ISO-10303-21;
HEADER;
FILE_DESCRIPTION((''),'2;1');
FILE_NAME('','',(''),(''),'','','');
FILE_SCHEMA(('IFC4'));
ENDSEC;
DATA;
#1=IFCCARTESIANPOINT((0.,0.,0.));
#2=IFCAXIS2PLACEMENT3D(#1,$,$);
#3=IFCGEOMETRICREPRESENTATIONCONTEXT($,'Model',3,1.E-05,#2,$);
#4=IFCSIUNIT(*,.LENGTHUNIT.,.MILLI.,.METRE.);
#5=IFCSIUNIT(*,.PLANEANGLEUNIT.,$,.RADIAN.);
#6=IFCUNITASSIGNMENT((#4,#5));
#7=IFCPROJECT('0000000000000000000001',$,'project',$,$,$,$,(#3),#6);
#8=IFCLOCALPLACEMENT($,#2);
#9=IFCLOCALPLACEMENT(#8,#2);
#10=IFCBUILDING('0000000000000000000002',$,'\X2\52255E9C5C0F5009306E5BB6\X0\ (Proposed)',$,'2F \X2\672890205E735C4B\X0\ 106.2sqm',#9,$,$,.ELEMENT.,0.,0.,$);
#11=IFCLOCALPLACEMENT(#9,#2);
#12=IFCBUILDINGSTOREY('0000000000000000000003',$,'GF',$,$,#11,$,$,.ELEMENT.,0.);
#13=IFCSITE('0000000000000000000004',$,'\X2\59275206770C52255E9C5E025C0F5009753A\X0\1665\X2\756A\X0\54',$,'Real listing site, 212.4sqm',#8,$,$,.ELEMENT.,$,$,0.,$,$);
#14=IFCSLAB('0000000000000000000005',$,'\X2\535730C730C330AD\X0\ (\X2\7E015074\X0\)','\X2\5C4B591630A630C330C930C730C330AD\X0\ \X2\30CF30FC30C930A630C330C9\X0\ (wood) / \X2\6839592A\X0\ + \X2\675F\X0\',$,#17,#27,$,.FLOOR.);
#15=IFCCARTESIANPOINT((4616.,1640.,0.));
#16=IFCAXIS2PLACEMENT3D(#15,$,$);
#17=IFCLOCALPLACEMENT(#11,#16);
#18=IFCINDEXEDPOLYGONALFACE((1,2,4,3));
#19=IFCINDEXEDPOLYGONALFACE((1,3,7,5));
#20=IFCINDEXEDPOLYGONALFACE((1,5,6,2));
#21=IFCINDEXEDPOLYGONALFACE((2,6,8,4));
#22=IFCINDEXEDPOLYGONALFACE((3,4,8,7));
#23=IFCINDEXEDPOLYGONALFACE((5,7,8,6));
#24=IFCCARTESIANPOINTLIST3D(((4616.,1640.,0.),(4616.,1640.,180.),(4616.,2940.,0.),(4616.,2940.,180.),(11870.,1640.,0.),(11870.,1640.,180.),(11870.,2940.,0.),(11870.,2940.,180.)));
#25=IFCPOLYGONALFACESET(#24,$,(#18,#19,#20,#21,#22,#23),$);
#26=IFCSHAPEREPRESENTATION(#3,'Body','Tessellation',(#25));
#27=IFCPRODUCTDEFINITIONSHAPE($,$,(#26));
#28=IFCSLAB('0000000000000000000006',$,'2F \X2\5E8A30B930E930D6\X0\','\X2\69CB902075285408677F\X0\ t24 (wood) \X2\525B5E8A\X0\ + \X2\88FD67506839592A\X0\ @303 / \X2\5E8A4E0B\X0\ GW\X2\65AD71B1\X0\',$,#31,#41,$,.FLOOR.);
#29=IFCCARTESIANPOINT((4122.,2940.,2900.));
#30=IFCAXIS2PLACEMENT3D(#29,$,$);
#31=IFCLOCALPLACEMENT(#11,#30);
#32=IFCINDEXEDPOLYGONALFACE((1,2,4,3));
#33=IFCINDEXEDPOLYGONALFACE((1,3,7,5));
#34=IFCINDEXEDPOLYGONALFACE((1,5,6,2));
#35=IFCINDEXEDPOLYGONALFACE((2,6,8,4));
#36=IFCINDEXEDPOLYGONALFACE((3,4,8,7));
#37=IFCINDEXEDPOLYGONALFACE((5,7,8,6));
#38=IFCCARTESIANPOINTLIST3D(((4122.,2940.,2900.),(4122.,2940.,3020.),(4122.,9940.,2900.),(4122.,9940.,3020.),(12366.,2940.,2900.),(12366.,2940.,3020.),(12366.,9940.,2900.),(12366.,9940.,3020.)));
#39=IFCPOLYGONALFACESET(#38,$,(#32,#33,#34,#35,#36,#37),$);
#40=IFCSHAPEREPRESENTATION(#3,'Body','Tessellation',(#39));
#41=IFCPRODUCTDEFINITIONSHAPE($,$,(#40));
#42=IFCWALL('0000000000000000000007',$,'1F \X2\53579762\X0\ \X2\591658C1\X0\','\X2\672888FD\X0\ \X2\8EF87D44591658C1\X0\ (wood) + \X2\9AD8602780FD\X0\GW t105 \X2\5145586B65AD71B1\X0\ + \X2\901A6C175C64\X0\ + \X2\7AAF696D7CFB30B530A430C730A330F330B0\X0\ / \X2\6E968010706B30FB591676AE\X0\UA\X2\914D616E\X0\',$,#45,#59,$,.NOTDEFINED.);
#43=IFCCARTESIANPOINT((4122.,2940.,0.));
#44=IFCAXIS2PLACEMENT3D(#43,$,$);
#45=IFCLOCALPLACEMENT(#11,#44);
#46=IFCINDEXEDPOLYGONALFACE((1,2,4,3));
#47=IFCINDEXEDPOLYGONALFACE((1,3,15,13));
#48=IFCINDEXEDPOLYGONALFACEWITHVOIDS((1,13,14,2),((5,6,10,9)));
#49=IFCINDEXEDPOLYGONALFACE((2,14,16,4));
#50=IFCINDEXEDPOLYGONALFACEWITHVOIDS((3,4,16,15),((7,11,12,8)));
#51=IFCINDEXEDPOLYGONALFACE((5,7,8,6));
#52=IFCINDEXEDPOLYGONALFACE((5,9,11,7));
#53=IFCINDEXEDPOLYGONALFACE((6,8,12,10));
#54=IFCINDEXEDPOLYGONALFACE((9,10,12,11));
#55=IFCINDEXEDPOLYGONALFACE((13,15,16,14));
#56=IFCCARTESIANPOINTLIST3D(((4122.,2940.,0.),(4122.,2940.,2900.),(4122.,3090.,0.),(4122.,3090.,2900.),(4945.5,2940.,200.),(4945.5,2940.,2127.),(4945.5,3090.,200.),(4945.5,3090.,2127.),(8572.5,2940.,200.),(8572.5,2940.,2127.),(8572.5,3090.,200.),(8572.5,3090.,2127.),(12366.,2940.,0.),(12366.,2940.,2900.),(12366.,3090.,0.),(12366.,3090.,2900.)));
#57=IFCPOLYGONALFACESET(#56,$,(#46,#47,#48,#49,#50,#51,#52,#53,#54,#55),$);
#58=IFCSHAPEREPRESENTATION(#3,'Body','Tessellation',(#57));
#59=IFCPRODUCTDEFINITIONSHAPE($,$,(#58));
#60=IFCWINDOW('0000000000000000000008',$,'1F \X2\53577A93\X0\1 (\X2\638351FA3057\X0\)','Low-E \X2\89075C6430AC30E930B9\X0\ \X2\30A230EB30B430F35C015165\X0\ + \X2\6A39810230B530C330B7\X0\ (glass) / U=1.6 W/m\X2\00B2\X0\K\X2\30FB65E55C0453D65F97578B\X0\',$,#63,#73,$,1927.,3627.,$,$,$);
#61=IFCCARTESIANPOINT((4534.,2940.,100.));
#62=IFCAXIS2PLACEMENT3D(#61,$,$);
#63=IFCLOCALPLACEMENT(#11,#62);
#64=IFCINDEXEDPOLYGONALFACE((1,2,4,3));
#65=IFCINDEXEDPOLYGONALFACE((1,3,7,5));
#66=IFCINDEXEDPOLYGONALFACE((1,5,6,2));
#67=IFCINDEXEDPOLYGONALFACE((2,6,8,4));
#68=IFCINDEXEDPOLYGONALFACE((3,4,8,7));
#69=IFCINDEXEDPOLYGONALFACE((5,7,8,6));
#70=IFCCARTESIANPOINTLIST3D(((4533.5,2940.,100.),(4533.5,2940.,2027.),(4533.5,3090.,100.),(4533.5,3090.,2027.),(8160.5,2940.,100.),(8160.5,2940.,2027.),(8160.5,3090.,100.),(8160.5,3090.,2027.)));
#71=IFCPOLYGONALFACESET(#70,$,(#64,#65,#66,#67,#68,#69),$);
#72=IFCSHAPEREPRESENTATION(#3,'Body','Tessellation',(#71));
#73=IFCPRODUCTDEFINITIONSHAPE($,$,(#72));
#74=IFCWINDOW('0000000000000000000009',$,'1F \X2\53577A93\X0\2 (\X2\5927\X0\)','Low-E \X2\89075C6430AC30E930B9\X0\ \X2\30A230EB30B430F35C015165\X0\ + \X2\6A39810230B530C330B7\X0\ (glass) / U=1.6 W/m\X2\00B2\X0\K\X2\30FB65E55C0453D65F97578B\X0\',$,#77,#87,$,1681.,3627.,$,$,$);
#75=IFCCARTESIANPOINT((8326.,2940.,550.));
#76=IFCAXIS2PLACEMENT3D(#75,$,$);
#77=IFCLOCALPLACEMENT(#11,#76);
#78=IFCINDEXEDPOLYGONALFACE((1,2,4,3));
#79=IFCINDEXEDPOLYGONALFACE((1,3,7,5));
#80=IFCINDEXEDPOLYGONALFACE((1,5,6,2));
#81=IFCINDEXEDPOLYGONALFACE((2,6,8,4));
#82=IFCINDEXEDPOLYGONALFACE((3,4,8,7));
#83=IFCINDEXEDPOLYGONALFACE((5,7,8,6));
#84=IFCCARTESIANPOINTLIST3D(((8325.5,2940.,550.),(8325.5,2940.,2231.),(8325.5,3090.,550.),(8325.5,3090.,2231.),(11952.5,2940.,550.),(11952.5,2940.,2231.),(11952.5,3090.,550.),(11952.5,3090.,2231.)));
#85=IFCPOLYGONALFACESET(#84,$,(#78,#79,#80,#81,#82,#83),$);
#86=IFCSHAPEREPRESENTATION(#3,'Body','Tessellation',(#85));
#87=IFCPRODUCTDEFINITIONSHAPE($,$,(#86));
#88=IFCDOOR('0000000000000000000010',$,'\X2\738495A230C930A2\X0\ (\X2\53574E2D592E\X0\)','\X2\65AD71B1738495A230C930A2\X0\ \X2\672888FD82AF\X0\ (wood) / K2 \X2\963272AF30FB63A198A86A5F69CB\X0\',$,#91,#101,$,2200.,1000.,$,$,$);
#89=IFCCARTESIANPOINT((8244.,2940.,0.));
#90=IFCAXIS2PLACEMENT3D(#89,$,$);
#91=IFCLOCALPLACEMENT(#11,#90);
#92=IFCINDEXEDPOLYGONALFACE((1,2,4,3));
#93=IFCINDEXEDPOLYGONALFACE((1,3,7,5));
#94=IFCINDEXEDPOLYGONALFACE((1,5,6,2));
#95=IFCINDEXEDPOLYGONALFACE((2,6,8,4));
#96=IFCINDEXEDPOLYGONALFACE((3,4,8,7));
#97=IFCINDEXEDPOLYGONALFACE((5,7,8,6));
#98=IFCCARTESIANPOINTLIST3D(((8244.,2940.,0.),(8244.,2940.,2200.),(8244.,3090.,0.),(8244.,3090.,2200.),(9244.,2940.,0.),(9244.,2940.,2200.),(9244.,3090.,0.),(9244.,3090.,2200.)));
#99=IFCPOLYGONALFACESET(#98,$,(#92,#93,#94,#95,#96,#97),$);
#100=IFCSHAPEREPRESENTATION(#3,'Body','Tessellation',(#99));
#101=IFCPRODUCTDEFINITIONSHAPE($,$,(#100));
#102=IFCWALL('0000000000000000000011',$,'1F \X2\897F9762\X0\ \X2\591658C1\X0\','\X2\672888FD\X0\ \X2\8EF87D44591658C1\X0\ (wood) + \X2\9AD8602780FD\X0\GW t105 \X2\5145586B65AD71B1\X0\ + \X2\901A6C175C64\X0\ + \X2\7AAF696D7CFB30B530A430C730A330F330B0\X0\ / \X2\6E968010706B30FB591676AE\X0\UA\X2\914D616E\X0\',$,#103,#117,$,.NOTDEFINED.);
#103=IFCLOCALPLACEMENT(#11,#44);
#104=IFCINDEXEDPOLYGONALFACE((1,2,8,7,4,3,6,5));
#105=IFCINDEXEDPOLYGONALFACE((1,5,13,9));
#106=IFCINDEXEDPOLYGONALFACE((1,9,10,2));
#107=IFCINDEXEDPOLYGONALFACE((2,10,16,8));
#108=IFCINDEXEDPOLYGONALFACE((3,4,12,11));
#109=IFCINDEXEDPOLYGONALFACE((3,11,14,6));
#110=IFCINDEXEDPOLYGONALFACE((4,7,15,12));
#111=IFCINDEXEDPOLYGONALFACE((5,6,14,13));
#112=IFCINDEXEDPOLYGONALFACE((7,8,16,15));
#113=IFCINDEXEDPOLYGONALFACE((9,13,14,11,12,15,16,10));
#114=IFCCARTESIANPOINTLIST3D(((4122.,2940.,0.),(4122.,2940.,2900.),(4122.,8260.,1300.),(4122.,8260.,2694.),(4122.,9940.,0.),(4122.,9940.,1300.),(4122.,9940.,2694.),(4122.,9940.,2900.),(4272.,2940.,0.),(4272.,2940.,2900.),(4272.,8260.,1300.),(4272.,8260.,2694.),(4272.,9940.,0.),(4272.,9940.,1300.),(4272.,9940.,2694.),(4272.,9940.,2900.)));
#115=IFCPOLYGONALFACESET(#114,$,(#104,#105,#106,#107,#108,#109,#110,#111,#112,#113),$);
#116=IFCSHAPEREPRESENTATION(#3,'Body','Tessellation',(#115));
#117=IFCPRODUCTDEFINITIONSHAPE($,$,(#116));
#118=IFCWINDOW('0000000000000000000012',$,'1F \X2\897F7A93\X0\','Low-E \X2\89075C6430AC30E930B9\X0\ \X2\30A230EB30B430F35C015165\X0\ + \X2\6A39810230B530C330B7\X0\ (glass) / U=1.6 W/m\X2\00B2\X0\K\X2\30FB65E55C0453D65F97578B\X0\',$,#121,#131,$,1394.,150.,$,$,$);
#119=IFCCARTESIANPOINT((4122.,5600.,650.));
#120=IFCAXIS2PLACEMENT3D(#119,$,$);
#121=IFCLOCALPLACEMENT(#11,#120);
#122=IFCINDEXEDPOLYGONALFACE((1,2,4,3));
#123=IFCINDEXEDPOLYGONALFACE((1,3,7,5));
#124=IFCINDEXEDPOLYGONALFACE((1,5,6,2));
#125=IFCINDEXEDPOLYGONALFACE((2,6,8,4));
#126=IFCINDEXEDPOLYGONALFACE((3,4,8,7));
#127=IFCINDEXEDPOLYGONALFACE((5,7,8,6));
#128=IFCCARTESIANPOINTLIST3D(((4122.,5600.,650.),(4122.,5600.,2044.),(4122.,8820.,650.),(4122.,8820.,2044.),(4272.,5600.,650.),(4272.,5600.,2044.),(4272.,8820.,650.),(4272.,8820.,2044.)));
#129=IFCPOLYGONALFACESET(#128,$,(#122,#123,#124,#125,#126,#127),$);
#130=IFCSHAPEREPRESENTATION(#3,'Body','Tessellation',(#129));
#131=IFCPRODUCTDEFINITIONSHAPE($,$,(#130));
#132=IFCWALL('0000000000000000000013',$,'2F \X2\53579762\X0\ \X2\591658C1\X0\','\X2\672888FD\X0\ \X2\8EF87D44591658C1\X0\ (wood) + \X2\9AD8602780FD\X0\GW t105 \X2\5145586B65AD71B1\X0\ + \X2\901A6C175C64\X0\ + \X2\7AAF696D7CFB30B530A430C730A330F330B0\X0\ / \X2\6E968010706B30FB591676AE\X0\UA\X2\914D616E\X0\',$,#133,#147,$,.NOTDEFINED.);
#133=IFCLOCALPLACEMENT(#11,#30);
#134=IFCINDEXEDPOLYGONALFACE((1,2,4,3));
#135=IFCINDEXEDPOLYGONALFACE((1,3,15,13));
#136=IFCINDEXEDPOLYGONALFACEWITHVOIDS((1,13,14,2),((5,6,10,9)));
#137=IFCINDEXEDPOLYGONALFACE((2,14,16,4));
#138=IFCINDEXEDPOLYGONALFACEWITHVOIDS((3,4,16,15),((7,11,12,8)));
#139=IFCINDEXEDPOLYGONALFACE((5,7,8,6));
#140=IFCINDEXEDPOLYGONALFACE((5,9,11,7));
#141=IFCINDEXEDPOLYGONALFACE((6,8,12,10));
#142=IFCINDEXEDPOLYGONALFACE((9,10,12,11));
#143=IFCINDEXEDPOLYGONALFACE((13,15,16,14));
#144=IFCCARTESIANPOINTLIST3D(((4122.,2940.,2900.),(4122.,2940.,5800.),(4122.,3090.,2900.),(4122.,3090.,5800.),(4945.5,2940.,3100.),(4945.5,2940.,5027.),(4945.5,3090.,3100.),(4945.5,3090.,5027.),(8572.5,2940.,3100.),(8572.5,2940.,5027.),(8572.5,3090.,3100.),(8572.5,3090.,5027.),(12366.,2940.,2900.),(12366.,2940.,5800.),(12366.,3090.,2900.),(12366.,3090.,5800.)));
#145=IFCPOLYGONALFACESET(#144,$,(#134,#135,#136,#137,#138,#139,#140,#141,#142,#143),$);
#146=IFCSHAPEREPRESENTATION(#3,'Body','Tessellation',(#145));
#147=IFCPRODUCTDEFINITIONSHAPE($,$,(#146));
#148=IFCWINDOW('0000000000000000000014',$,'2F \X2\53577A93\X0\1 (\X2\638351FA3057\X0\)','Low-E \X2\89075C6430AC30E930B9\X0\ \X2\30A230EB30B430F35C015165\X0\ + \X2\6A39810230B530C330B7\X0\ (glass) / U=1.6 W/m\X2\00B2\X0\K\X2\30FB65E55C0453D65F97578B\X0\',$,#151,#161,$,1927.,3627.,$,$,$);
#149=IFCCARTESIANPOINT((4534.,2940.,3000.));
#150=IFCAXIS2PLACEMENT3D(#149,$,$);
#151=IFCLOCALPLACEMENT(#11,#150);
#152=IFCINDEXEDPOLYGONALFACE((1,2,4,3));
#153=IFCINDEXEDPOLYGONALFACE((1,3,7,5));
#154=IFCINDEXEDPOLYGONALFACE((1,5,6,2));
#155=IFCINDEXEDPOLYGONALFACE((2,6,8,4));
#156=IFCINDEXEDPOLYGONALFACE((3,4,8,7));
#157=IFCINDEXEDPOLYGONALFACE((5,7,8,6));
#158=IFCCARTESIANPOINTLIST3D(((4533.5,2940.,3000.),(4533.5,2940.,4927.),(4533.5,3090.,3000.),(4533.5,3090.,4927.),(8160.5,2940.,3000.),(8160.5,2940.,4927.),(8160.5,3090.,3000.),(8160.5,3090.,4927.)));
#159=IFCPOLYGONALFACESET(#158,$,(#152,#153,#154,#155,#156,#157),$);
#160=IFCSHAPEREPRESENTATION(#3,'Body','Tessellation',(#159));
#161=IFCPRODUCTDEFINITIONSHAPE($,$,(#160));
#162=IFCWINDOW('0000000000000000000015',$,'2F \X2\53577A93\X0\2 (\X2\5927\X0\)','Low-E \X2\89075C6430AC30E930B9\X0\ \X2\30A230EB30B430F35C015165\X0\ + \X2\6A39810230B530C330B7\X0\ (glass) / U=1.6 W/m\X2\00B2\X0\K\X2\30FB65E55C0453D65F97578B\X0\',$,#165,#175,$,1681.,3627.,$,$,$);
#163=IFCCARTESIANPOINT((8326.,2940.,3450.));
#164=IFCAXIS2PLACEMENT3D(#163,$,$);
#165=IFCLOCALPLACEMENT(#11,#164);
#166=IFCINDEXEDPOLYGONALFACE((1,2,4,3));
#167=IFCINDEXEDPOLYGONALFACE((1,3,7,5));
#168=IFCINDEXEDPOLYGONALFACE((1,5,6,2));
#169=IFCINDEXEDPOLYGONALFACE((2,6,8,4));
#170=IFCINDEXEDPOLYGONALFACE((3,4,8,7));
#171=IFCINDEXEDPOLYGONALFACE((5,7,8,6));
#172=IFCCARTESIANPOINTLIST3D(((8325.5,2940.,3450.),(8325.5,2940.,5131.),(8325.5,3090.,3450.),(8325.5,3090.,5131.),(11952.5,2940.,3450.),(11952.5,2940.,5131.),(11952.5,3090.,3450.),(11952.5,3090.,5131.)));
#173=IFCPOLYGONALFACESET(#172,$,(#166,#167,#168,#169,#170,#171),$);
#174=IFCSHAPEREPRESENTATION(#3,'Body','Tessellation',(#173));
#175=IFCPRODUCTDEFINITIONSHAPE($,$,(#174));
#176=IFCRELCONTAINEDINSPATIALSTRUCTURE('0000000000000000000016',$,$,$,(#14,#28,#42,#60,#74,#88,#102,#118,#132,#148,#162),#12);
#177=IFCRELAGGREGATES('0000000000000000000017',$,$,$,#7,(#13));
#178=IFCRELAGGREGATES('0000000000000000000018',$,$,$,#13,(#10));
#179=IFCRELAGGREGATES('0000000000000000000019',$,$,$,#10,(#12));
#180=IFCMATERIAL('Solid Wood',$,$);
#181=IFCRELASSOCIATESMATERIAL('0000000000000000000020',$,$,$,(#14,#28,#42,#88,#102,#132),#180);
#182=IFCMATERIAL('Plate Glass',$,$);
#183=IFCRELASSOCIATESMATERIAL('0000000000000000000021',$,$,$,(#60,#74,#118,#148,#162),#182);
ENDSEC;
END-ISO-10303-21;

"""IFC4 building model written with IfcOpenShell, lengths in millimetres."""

from ifc_helpers import new_model, si_unit, frame, frame_2d, origin, place, context, project, spatial, rectangle, extrude, material, element, fill, save


model = new_model("IFC4")

# Units and contexts
model_context = context("Model", 3, precision=1e-05, world=origin())
ifc_project = project(units=[si_unit("LENGTHUNIT", "METRE", prefix="MILLI"), si_unit("PLANEANGLEUNIT", "RADIAN")], contexts=[model_context])

# Site, building, storey
site_placement = place(None, origin())
site = spatial("IfcSite", under=ifc_project, at=site_placement, Name="大分県別府市小倉町1665番54", ObjectType="Real listing site, 212.4sqm", CompositionType="ELEMENT", RefElevation=0.0)
building_placement = place(site_placement, origin())
building = spatial("IfcBuilding", under=site, at=building_placement, Name="別府小倉の家 (Proposed)", ObjectType="2F 木造平屋 106.2sqm", CompositionType="ELEMENT", ElevationOfRefHeight=0.0, ElevationOfTerrain=0.0)
storey_placement = place(building_placement, origin())
storey = spatial("IfcBuildingStorey", under=building, at=storey_placement, Name="GF", CompositionType="ELEMENT", Elevation=0.0)

# Slabs
ifc_material_1 = material(Name="Solid Wood")
slab_1_placement = place(storey_placement, frame((4616.0, 1640.0, 0.0)))
element("IfcSlab", 1, at=slab_1_placement, inside=storey, material=ifc_material_1, Name="南デッキ (縁側)", Description="屋外ウッドデッキ ハードウッド (wood) / 根太 + 束", PredefinedType="FLOOR", context=model_context, shape_type="SweptSolid", body=[
    extrude(rectangle(XDim=7254.0, YDim=1300.0, at=frame_2d((3627.0, 650.0))), frame((4616.0, 1640.0, 0.0)), (0.0, 0.0, 1.0), 180.0),
])
slab_2_placement = place(storey_placement, frame((4122.0, 2940.0, 2900.0)))
element("IfcSlab", 2, at=slab_2_placement, inside=storey, material=ifc_material_1, Name="2F 床スラブ", Description="構造用合板 t24 (wood) 剛床 + 製材根太 @303 / 床下 GW断熱", PredefinedType="FLOOR", context=model_context, shape_type="SweptSolid", body=[
    extrude(rectangle(XDim=8244.0, YDim=7000.0, at=frame_2d((4122.0, 3500.0))), frame((4122.0, 2940.0, 2900.0)), (0.0, 0.0, 1.0), 120.0),
])

# Wall, openings, windows, door
wall_1_placement = place(storey_placement, frame((4122.0, 2940.0, 0.0)))
wall_1 = element("IfcWall", 3, at=wall_1_placement, inside=storey, material=ifc_material_1, Name="1F 南面 外壁", Description="木製 軸組外壁 (wood) + 高性能GW t105 充填断熱 + 通気層 + 窯業系サイディング / 準耐火・外皮UA配慮", PredefinedType="NOTDEFINED", context=model_context, shape_type="SweptSolid", body=[
    extrude(rectangle(XDim=8244.0, YDim=150.0, at=frame_2d((4122.0, 75.0))), frame((4122.0, 2940.0, 0.0)), (0.0, 0.0, 1.0), 2900.0),
])
opening_1_placement = place(storey_placement, frame((4534.0, 2940.0, 100.0)))
opening_1 = element("IfcOpeningElement", 4, at=opening_1_placement, cuts=wall_1, PredefinedType="NOTDEFINED", context=model_context, shape_type="SweptSolid", body=[
    extrude(rectangle(XDim=3627.0, YDim=150.0, at=frame_2d((1813.0, 75.0))), frame((4534.0, 2940.0, 100.0)), (0.0, 0.0, 1.0), 1927.0),
])
opening_2_placement = place(storey_placement, frame((8326.0, 2940.0, 550.0)))
opening_2 = element("IfcOpeningElement", 5, at=opening_2_placement, cuts=wall_1, PredefinedType="NOTDEFINED", context=model_context, shape_type="SweptSolid", body=[
    extrude(rectangle(XDim=3627.0, YDim=150.0, at=frame_2d((1813.0, 75.0))), frame((8326.0, 2940.0, 550.0)), (0.0, 0.0, 1.0), 1681.0),
])
opening_3_placement = place(storey_placement, frame((8244.0, 2940.0, 0.0)))
opening_3 = element("IfcOpeningElement", 6, at=opening_3_placement, cuts=wall_1, PredefinedType="NOTDEFINED", context=model_context, shape_type="SweptSolid", body=[
    extrude(rectangle(XDim=1000.0, YDim=150.0, at=frame_2d((500.0, 75.0))), frame((8244.0, 2940.0, 0.0)), (0.0, 0.0, 1.0), 2200.0),
])
ifc_material_2 = material(Name="Plate Glass")
window_1_placement = place(storey_placement, frame((4534.0, 2940.0, 100.0)))
window_1 = element("IfcWindow", 7, at=window_1_placement, inside=storey, material=ifc_material_2, Name="1F 南窓1 (掃出し)", Description="Low-E 複層ガラス アルゴン封入 + 樹脂サッシ (glass) / U=1.6 W/m²K・日射取得型", OverallHeight=1927.0, OverallWidth=3627.0, context=model_context, shape_type="SweptSolid", body=[
    extrude(rectangle(XDim=3627.0, YDim=150.0, at=frame_2d((1813.0, 75.0))), frame((4534.0, 2940.0, 100.0)), (0.0, 0.0, 1.0), 1927.0),
])
fill(opening_1, window_1)
window_2_placement = place(storey_placement, frame((8326.0, 2940.0, 550.0)))
window_2 = element("IfcWindow", 8, at=window_2_placement, inside=storey, material=ifc_material_2, Name="1F 南窓2 (大)", Description="Low-E 複層ガラス アルゴン封入 + 樹脂サッシ (glass) / U=1.6 W/m²K・日射取得型", OverallHeight=1681.0, OverallWidth=3627.0, context=model_context, shape_type="SweptSolid", body=[
    extrude(rectangle(XDim=3627.0, YDim=150.0, at=frame_2d((1813.0, 75.0))), frame((8326.0, 2940.0, 550.0)), (0.0, 0.0, 1.0), 1681.0),
])
fill(opening_2, window_2)
door_placement = place(storey_placement, frame((8244.0, 2940.0, 0.0)))
door = element("IfcDoor", 9, at=door_placement, inside=storey, material=ifc_material_1, Name="玄関ドア (南中央)", Description="断熱玄関ドア 木製芯 (wood) / K2 防犯・採風機構", OverallHeight=2200.0, OverallWidth=1000.0, context=model_context, shape_type="SweptSolid", body=[
    extrude(rectangle(XDim=1000.0, YDim=150.0, at=frame_2d((500.0, 75.0))), frame((8244.0, 2940.0, 0.0)), (0.0, 0.0, 1.0), 2200.0),
])
fill(opening_3, door)

# Wall, opening, window
wall_2_placement = place(storey_placement, frame((4122.0, 2940.0, 0.0)))
wall_2 = element("IfcWall", 10, at=wall_2_placement, inside=storey, material=ifc_material_1, Name="1F 西面 外壁", Description="木製 軸組外壁 (wood) + 高性能GW t105 充填断熱 + 通気層 + 窯業系サイディング / 準耐火・外皮UA配慮", PredefinedType="NOTDEFINED", context=model_context, shape_type="SweptSolid", body=[
    extrude(rectangle(XDim=150.0, YDim=7000.0, at=frame_2d((75.0, 3500.0))), frame((4122.0, 2940.0, 0.0)), (0.0, 0.0, 1.0), 2900.0),
])
opening_4_placement = place(storey_placement, frame((4122.0, 5600.0, 650.0)))
opening_4 = element("IfcOpeningElement", 11, at=opening_4_placement, cuts=wall_2, PredefinedType="NOTDEFINED", context=model_context, shape_type="SweptSolid", body=[
    extrude(rectangle(XDim=150.0, YDim=3220.0, at=frame_2d((75.0, 1610.0))), frame((4122.0, 5600.0, 650.0)), (0.0, 0.0, 1.0), 1394.0),
])
window_3_placement = place(storey_placement, frame((4122.0, 5600.0, 650.0)))
window_3 = element("IfcWindow", 12, at=window_3_placement, inside=storey, material=ifc_material_2, Name="1F 西窓", Description="Low-E 複層ガラス アルゴン封入 + 樹脂サッシ (glass) / U=1.6 W/m²K・日射取得型", OverallHeight=1394.0, OverallWidth=150.0, context=model_context, shape_type="SweptSolid", body=[
    extrude(rectangle(XDim=150.0, YDim=3220.0, at=frame_2d((75.0, 1610.0))), frame((4122.0, 5600.0, 650.0)), (0.0, 0.0, 1.0), 1394.0),
])
fill(opening_4, window_3)

# Wall, openings, windows
wall_3_placement = place(storey_placement, frame((4122.0, 2940.0, 2900.0)))
wall_3 = element("IfcWall", 13, at=wall_3_placement, inside=storey, material=ifc_material_1, Name="2F 南面 外壁", Description="木製 軸組外壁 (wood) + 高性能GW t105 充填断熱 + 通気層 + 窯業系サイディング / 準耐火・外皮UA配慮", PredefinedType="NOTDEFINED", context=model_context, shape_type="SweptSolid", body=[
    extrude(rectangle(XDim=8244.0, YDim=150.0, at=frame_2d((4122.0, 75.0))), frame((4122.0, 2940.0, 2900.0)), (0.0, 0.0, 1.0), 2900.0),
])
opening_5_placement = place(storey_placement, frame((4534.0, 2940.0, 3000.0)))
opening_5 = element("IfcOpeningElement", 14, at=opening_5_placement, cuts=wall_3, PredefinedType="NOTDEFINED", context=model_context, shape_type="SweptSolid", body=[
    extrude(rectangle(XDim=3627.0, YDim=150.0, at=frame_2d((1813.0, 75.0))), frame((4534.0, 2940.0, 3000.0)), (0.0, 0.0, 1.0), 1927.0),
])
opening_6_placement = place(storey_placement, frame((8326.0, 2940.0, 3450.0)))
opening_6 = element("IfcOpeningElement", 15, at=opening_6_placement, cuts=wall_3, PredefinedType="NOTDEFINED", context=model_context, shape_type="SweptSolid", body=[
    extrude(rectangle(XDim=3627.0, YDim=150.0, at=frame_2d((1813.0, 75.0))), frame((8326.0, 2940.0, 3450.0)), (0.0, 0.0, 1.0), 1681.0),
])
window_4_placement = place(storey_placement, frame((4534.0, 2940.0, 3000.0)))
window_4 = element("IfcWindow", 16, at=window_4_placement, inside=storey, material=ifc_material_2, Name="2F 南窓1 (掃出し)", Description="Low-E 複層ガラス アルゴン封入 + 樹脂サッシ (glass) / U=1.6 W/m²K・日射取得型", OverallHeight=1927.0, OverallWidth=3627.0, context=model_context, shape_type="SweptSolid", body=[
    extrude(rectangle(XDim=3627.0, YDim=150.0, at=frame_2d((1813.0, 75.0))), frame((4534.0, 2940.0, 3000.0)), (0.0, 0.0, 1.0), 1927.0),
])
fill(opening_5, window_4)
window_5_placement = place(storey_placement, frame((8326.0, 2940.0, 3450.0)))
window_5 = element("IfcWindow", 17, at=window_5_placement, inside=storey, material=ifc_material_2, Name="2F 南窓2 (大)", Description="Low-E 複層ガラス アルゴン封入 + 樹脂サッシ (glass) / U=1.6 W/m²K・日射取得型", OverallHeight=1681.0, OverallWidth=3627.0, context=model_context, shape_type="SweptSolid", body=[
    extrude(rectangle(XDim=3627.0, YDim=150.0, at=frame_2d((1813.0, 75.0))), frame((8326.0, 2940.0, 3450.0)), (0.0, 0.0, 1.0), 1681.0),
])
fill(opening_6, window_5)

save(model, "model.ifc")
